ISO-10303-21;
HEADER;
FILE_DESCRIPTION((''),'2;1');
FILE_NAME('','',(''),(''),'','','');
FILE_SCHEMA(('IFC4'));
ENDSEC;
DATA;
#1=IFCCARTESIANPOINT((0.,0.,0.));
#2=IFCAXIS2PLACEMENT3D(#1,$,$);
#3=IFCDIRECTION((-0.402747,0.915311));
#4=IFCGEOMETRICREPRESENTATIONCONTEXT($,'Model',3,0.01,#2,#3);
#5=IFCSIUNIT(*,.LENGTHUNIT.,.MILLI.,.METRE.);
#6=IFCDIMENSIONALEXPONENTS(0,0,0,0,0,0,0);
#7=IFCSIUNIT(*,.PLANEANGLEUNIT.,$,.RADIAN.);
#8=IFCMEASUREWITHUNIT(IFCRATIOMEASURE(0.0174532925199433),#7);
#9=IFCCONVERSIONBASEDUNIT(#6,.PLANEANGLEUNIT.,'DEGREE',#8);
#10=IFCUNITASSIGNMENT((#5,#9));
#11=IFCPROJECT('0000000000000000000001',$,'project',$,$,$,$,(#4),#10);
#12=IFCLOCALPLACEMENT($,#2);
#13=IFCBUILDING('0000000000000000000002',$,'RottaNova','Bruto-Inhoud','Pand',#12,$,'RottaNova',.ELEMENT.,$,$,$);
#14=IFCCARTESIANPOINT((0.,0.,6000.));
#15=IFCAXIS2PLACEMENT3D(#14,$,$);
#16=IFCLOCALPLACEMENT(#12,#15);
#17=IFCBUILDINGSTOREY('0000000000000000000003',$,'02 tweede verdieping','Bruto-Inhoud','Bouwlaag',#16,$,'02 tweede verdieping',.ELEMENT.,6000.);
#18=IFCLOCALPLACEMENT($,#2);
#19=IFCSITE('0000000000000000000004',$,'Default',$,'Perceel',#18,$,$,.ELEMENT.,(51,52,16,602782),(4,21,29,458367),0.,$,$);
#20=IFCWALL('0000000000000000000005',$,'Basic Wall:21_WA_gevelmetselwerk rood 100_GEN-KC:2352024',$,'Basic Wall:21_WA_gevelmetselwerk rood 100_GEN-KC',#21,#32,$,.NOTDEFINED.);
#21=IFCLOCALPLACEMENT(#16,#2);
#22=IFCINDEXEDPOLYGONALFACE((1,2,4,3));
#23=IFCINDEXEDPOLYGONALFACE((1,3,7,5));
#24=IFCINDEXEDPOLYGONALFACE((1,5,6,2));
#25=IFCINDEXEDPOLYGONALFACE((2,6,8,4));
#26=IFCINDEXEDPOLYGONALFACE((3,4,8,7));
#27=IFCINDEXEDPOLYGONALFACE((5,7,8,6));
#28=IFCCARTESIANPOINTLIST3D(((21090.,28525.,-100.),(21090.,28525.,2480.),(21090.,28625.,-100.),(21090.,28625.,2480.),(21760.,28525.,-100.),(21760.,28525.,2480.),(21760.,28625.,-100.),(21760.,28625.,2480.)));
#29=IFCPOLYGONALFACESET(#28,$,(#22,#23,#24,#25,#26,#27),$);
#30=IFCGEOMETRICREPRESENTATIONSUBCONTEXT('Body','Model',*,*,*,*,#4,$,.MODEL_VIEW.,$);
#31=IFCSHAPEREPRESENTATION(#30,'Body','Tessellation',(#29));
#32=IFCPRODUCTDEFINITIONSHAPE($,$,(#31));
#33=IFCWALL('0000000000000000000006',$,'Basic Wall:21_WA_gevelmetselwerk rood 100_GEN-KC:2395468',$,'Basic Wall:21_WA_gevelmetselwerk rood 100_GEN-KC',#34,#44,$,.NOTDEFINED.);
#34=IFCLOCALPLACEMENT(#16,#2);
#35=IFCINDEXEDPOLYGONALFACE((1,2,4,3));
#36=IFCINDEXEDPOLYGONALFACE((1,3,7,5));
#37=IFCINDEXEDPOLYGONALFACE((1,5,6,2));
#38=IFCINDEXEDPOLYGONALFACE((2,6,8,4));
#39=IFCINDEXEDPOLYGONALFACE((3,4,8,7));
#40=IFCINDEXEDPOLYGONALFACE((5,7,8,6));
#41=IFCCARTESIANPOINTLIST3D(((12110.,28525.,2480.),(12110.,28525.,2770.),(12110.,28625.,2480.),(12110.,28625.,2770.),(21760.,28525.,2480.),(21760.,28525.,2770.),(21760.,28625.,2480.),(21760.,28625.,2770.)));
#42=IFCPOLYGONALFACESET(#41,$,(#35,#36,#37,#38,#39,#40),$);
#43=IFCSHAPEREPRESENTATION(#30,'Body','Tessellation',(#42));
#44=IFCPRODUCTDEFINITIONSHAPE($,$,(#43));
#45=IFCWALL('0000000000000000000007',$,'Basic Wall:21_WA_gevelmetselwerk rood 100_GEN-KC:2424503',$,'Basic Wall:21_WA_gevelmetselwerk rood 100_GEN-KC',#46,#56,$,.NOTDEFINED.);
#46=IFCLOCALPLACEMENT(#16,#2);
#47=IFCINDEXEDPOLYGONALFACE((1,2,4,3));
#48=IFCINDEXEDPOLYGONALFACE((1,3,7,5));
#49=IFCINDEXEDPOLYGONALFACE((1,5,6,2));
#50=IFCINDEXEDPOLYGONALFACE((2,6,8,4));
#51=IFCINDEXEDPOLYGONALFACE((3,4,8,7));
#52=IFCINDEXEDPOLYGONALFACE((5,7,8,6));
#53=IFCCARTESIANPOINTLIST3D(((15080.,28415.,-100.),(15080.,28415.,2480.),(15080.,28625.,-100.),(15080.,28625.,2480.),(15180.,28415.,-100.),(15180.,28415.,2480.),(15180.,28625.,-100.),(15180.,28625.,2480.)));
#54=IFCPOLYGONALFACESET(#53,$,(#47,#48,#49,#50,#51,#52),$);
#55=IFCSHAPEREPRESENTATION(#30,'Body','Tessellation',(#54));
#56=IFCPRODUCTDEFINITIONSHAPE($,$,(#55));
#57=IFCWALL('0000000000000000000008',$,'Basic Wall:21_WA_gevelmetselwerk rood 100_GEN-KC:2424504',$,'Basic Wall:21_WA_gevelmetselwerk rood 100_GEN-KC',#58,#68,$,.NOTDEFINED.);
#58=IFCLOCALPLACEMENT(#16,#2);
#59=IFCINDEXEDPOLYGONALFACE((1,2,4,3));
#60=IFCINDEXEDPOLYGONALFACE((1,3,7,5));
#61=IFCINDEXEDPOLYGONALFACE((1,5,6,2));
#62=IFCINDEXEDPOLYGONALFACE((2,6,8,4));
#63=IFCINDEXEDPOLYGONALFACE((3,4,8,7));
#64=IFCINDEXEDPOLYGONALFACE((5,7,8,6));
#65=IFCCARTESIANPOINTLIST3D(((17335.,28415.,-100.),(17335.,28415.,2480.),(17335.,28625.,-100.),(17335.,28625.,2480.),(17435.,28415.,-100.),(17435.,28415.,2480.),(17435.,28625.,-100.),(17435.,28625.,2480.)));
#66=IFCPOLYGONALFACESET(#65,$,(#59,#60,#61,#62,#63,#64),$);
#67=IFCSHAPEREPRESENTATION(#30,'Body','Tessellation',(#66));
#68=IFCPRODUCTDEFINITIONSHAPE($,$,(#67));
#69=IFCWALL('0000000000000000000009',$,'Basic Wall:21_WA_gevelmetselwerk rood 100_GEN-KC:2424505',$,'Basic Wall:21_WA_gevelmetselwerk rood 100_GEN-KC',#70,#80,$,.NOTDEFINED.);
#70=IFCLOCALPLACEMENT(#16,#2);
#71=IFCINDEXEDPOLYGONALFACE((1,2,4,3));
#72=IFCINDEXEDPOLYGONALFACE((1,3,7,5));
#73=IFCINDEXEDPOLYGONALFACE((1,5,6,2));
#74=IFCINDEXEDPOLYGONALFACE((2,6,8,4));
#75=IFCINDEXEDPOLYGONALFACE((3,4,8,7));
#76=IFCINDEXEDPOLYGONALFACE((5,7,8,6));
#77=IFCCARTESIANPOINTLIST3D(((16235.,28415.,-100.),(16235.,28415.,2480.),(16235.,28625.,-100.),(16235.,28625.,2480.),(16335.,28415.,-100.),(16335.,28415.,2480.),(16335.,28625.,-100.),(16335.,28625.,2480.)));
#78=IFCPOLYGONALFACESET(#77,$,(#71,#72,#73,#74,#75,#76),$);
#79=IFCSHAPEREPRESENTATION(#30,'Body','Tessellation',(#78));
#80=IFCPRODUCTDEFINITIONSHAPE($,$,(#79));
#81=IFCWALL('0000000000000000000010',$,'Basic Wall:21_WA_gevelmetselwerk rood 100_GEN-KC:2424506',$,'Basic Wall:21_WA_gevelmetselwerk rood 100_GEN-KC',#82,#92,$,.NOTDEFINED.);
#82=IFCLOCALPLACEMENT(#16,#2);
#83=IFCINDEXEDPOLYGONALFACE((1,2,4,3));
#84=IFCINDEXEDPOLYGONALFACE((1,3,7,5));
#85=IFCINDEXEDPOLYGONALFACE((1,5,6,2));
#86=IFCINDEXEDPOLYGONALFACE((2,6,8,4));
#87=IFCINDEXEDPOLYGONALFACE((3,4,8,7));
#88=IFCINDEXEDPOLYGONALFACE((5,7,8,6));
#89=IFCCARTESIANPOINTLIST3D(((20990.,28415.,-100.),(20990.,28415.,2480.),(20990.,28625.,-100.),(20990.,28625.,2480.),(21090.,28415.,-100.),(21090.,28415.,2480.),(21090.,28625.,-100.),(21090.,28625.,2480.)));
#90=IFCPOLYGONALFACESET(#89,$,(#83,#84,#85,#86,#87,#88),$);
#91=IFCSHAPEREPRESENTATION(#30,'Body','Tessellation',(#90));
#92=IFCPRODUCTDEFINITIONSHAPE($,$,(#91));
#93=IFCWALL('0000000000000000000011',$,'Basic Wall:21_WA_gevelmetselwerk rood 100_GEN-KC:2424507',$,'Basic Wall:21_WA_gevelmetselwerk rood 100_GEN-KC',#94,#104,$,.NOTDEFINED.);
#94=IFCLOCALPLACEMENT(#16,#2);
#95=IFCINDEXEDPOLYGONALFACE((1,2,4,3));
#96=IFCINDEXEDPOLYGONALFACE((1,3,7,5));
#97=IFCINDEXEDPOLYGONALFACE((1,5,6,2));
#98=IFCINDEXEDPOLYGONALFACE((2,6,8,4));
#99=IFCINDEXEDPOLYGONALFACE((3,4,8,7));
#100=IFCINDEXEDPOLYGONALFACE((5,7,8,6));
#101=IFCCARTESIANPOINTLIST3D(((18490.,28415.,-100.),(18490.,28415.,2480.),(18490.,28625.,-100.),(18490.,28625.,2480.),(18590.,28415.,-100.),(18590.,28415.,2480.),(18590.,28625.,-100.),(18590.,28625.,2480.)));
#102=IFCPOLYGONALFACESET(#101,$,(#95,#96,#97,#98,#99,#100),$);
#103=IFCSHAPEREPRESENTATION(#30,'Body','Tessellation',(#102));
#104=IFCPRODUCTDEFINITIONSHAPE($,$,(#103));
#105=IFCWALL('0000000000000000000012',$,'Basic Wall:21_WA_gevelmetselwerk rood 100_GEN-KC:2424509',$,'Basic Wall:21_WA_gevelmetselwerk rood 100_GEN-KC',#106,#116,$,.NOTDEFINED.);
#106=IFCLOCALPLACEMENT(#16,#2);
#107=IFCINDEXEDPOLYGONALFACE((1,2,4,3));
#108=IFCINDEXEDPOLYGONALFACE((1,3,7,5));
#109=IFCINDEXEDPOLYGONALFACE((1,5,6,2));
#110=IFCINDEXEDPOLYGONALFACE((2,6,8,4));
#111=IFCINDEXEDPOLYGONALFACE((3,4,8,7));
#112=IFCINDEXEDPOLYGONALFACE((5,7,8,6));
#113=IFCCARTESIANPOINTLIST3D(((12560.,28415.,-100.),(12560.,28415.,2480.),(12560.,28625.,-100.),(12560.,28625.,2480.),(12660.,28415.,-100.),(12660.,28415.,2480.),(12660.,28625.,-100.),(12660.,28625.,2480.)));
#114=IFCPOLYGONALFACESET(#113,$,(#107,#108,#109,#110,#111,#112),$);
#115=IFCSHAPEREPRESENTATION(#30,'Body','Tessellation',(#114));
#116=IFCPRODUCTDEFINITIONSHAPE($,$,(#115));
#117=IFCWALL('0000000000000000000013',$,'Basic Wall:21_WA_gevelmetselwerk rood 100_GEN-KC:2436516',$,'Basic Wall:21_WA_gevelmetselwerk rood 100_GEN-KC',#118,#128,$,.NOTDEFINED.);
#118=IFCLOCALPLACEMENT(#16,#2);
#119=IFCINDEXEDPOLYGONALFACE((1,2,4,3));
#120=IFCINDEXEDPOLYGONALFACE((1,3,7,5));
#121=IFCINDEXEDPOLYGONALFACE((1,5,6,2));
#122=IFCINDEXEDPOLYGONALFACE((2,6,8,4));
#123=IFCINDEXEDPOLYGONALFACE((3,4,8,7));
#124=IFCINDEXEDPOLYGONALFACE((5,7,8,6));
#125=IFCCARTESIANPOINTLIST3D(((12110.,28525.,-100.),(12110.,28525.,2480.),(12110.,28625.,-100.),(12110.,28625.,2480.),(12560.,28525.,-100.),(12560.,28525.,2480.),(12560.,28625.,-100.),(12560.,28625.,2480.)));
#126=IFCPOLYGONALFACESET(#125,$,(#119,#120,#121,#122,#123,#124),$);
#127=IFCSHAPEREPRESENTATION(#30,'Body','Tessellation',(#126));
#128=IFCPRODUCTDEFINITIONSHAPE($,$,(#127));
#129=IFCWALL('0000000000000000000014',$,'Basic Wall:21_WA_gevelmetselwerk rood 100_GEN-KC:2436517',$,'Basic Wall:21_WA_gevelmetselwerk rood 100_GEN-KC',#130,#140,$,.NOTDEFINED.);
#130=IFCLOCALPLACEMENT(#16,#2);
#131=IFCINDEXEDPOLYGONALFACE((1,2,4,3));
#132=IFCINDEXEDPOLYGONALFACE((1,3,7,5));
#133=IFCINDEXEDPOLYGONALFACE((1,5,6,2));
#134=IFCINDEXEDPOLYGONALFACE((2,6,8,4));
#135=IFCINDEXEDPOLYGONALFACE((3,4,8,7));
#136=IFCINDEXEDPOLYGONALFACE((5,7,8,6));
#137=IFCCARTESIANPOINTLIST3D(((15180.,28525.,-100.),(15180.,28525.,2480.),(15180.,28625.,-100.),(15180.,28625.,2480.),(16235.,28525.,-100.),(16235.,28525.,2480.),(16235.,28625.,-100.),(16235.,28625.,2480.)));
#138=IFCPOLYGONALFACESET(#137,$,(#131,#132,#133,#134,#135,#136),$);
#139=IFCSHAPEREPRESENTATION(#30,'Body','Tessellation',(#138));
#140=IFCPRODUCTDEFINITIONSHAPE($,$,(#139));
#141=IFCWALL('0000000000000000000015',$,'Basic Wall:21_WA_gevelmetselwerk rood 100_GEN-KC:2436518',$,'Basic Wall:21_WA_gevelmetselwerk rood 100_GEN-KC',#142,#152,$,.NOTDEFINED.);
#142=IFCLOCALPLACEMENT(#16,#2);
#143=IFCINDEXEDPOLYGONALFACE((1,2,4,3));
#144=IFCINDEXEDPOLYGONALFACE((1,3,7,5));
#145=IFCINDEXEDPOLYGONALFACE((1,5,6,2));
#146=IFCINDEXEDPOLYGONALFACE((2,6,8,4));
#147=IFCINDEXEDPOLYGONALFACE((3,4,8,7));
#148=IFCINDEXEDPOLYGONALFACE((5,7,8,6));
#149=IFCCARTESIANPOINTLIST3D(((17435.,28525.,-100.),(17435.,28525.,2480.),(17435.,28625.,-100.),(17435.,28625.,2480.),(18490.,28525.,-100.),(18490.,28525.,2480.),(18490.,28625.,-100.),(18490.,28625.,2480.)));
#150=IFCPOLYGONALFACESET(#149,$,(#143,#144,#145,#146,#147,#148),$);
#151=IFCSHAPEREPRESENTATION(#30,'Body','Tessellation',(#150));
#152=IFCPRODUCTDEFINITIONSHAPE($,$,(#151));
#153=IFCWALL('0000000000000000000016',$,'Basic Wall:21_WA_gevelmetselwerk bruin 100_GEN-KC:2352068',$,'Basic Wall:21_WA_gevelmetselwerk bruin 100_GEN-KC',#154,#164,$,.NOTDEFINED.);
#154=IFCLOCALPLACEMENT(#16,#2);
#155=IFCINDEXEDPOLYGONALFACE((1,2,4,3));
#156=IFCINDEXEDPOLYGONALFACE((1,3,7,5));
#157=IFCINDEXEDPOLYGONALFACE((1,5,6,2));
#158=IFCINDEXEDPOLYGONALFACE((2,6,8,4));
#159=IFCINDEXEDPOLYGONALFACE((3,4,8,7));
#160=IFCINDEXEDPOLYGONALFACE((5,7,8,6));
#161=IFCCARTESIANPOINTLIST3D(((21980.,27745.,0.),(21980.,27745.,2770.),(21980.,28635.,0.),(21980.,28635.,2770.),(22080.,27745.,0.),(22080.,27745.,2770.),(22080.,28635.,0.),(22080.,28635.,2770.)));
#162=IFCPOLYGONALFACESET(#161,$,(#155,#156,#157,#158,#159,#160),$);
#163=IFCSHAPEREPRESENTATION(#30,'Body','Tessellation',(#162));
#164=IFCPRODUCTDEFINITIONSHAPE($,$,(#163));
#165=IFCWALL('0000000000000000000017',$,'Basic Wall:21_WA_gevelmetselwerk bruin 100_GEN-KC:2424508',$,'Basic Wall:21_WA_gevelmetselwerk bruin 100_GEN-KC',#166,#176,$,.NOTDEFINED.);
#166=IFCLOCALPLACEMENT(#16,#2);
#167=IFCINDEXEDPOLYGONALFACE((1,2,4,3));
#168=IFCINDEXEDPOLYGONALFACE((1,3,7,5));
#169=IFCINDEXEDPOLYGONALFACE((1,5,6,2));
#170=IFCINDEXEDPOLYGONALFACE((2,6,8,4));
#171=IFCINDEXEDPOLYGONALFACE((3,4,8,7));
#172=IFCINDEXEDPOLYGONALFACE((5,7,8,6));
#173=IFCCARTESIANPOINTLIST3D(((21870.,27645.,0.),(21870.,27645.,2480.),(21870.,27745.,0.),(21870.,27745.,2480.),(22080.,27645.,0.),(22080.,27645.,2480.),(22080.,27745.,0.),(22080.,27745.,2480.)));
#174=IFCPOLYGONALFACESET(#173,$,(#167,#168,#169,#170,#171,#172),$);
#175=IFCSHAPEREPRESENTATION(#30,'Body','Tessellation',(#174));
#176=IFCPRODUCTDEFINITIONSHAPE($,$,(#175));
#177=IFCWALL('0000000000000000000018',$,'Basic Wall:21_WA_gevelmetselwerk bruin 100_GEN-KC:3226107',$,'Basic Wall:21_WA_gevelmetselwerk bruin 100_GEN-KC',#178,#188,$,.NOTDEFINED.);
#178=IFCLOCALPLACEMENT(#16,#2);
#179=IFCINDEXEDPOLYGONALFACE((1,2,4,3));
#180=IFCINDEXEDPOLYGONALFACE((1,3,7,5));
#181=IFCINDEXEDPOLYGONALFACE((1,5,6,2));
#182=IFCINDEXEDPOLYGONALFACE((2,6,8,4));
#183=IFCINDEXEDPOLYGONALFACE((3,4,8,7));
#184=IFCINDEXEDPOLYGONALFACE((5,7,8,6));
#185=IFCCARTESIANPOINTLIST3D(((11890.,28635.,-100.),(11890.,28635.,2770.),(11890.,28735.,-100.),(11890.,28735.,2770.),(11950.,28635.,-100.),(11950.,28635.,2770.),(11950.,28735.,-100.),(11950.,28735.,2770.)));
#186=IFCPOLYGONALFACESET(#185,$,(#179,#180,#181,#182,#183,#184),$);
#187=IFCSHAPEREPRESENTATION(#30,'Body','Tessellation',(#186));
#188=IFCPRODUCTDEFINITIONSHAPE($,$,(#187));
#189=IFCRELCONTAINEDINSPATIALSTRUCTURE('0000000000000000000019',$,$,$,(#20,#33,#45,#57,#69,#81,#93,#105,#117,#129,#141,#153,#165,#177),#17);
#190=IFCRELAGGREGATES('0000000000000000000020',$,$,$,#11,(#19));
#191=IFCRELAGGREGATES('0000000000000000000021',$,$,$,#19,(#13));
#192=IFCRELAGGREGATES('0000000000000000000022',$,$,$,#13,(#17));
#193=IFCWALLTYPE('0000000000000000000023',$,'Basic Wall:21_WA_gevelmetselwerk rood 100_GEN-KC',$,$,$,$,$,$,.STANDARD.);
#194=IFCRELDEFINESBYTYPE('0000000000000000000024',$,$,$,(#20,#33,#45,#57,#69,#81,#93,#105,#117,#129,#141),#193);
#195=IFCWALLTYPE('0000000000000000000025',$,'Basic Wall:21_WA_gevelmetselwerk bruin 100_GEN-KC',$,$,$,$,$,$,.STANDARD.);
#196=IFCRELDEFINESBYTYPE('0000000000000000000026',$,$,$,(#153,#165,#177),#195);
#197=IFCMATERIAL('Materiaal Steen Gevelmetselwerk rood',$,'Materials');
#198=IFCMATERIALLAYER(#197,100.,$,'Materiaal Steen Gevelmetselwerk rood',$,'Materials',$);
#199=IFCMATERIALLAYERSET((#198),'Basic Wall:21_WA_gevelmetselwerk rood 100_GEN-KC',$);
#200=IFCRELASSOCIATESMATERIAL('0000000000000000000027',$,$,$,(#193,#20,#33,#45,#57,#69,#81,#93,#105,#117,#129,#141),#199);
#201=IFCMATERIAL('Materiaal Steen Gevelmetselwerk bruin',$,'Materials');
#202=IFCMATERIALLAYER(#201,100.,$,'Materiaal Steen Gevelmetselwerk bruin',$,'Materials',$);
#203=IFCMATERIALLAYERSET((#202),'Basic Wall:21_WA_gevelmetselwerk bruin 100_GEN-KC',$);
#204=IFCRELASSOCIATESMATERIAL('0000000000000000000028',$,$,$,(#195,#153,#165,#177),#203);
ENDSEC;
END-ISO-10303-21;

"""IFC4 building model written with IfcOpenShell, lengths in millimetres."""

from ifc_helpers import new_model, entity, si_unit, converted_unit, direction, frame, frame_2d, origin, place, context, subcontext, project, spatial, rectangle, extrude, material, layer, layer_set, type_object, element, save


model = new_model("IFC4")

# Units and contexts
model_context = context("Model", 3, precision=0.01, world=origin(), true_north=direction((-0.402747, 0.915311)))
body_context = subcontext(model_context, "Body", "Model", "MODEL_VIEW")
ifc_project = project(units=[si_unit("LENGTHUNIT", "METRE", prefix="MILLI"), converted_unit("PLANEANGLEUNIT", "DEGREE", entity("IfcRatioMeasure", 0.0174532925199433), si_unit("PLANEANGLEUNIT", "RADIAN"), dimensions=[0, 0, 0, 0, 0, 0, 0])], contexts=[model_context])

# Site, building, storey
site_placement = place(None, origin())
site = spatial("IfcSite", under=ifc_project, at=site_placement, Name="Default", ObjectType="Perceel", CompositionType="ELEMENT", RefLatitude=(51, 52, 16, 602782), RefLongitude=(4, 21, 29, 458367), RefElevation=0.0)
building_placement = place(None, origin())
building = spatial("IfcBuilding", under=site, at=building_placement, Name="RottaNova", Description="Bruto-Inhoud", ObjectType="Pand", LongName="RottaNova", CompositionType="ELEMENT")
storey_placement = place(building_placement, frame((0.0, 0.0, 6000.0)))
storey = spatial("IfcBuildingStorey", under=building, at=storey_placement, Name="02 tweede verdieping", Description="Bruto-Inhoud", ObjectType="Bouwlaag", LongName="02 tweede verdieping", CompositionType="ELEMENT", Elevation=6000.0)

# Walls
ifc_material_1 = material(Name="Materiaal Steen Gevelmetselwerk rood", Category="Materials")
ifc_layer_1 = layer(ifc_material_1, 100.0, Name="Materiaal Steen Gevelmetselwerk rood", Category="Materials")
ifc_layer_set_1 = layer_set([ifc_layer_1], Name="Basic Wall:21_WA_gevelmetselwerk rood 100_GEN-KC")
wall_type_1 = type_object("IfcWallType", Name="Basic Wall:21_WA_gevelmetselwerk rood 100_GEN-KC", PredefinedType="STANDARD", material=ifc_layer_set_1)
wall_1_placement = place(storey_placement, frame((21760.0, 28575.0, -100.0), z_axis=(0.0, 0.0, 1.0), x_axis=(-1.0, 0.0, 0.0)))
element("IfcWall", 1, at=wall_1_placement, inside=storey, type_object=wall_type_1, material=ifc_layer_set_1, Name="Basic Wall:21_WA_gevelmetselwerk rood 100_GEN-KC:2352024", ObjectType="Basic Wall:21_WA_gevelmetselwerk rood 100_GEN-KC", PredefinedType="NOTDEFINED", context=body_context, shape_type="SweptSolid", body=[
    extrude(rectangle(XDim=670.0, YDim=100.0, at=frame_2d((335.0, 0.0), x_axis=(-1.0, 0.0))), origin(), (0.0, 0.0, 1.0), 2580.0),
])
wall_2_placement = place(storey_placement, frame((21760.0, 28575.0, 2480.0), z_axis=(0.0, 0.0, 1.0), x_axis=(-1.0, 0.0, 0.0)))
element("IfcWall", 2, at=wall_2_placement, inside=storey, type_object=wall_type_1, material=ifc_layer_set_1, Name="Basic Wall:21_WA_gevelmetselwerk rood 100_GEN-KC:2395468", ObjectType="Basic Wall:21_WA_gevelmetselwerk rood 100_GEN-KC", PredefinedType="NOTDEFINED", context=body_context, shape_type="SweptSolid", body=[
    extrude(rectangle(XDim=9650.0, YDim=100.0, at=frame_2d((4825.0, 0.0), x_axis=(-1.0, 0.0))), origin(), (0.0, 0.0, 1.0), 290.0),
])
for number, where, z_axis, x_axis, name in (
    (3, (15130.0, 28415.0, -100.0), (0.0, 0.0, 1.0), (0.0, 1.0, 0.0), "Basic Wall:21_WA_gevelmetselwerk rood 100_GEN-KC:2424503"),
    (4, (17385.0, 28415.0, -100.0), (0.0, 0.0, 1.0), (0.0, 1.0, 0.0), "Basic Wall:21_WA_gevelmetselwerk rood 100_GEN-KC:2424504"),
    (5, (16285.0, 28415.0, -100.0), (0.0, 0.0, 1.0), (0.0, 1.0, 0.0), "Basic Wall:21_WA_gevelmetselwerk rood 100_GEN-KC:2424505"),
):
    element("IfcWall", number, at=place(storey_placement, frame(where, z_axis=z_axis, x_axis=x_axis)), inside=storey, type_object=wall_type_1, material=ifc_layer_set_1, Name=name, ObjectType="Basic Wall:21_WA_gevelmetselwerk rood 100_GEN-KC", PredefinedType="NOTDEFINED", context=body_context, shape_type="SweptSolid", body=[
        extrude(rectangle(XDim=210.0, YDim=100.0, at=frame_2d((105.0, 0.0), x_axis=(-1.0, 0.0))), origin(), (0.0, 0.0, 1.0), 2580.0),
    ])
wall_3_placement = place(storey_placement, frame((21040.0, 28415.0, -100.0), z_axis=(0.0, 0.0, 1.0), x_axis=(0.0, 1.0, 0.0)))
element("IfcWall", 6, at=wall_3_placement, inside=storey, type_object=wall_type_1, material=ifc_layer_set_1, Name="Basic Wall:21_WA_gevelmetselwerk rood 100_GEN-KC:2424506", ObjectType="Basic Wall:21_WA_gevelmetselwerk rood 100_GEN-KC", PredefinedType="NOTDEFINED", context=body_context, shape_type="SweptSolid", body=[
    extrude(rectangle(XDim=210.0, YDim=100.0, at=frame_2d((105.0, 0.0), x_axis=(-1.0, 0.0))), origin(), (0.0, 0.0, 1.0), 2580.0),
])
wall_4_placement = place(storey_placement, frame((18540.0, 28415.0, -100.0), z_axis=(0.0, 0.0, 1.0), x_axis=(0.0, 1.0, 0.0)))
element("IfcWall", 7, at=wall_4_placement, inside=storey, type_object=wall_type_1, material=ifc_layer_set_1, Name="Basic Wall:21_WA_gevelmetselwerk rood 100_GEN-KC:2424507", ObjectType="Basic Wall:21_WA_gevelmetselwerk rood 100_GEN-KC", PredefinedType="NOTDEFINED", context=body_context, shape_type="SweptSolid", body=[
    extrude(rectangle(XDim=210.0, YDim=100.0, at=frame_2d((105.0, 0.0), x_axis=(-1.0, 0.0))), origin(), (0.0, 0.0, 1.0), 2580.0),
])
wall_5_placement = place(storey_placement, frame((12610.0, 28415.0, -100.0), z_axis=(0.0, 0.0, 1.0), x_axis=(0.0, 1.0, 0.0)))
element("IfcWall", 8, at=wall_5_placement, inside=storey, type_object=wall_type_1, material=ifc_layer_set_1, Name="Basic Wall:21_WA_gevelmetselwerk rood 100_GEN-KC:2424509", ObjectType="Basic Wall:21_WA_gevelmetselwerk rood 100_GEN-KC", PredefinedType="NOTDEFINED", context=body_context, shape_type="SweptSolid", body=[
    extrude(rectangle(XDim=210.0, YDim=100.0, at=frame_2d((105.0, 0.0), x_axis=(-1.0, 0.0))), origin(), (0.0, 0.0, 1.0), 2580.0),
])
wall_6_placement = place(storey_placement, frame((12560.0, 28575.0, -100.0), z_axis=(0.0, 0.0, 1.0), x_axis=(-1.0, 0.0, 0.0)))
element("IfcWall", 9, at=wall_6_placement, inside=storey, type_object=wall_type_1, material=ifc_layer_set_1, Name="Basic Wall:21_WA_gevelmetselwerk rood 100_GEN-KC:2436516", ObjectType="Basic Wall:21_WA_gevelmetselwerk rood 100_GEN-KC", PredefinedType="NOTDEFINED", context=body_context, shape_type="SweptSolid", body=[
    extrude(rectangle(XDim=450.0, YDim=100.0, at=frame_2d((225.0, 0.0), x_axis=(-1.0, 0.0))), origin(), (0.0, 0.0, 1.0), 2580.0),
])
wall_7_placement = place(storey_placement, frame((16235.0, 28575.0, -100.0), z_axis=(0.0, 0.0, 1.0), x_axis=(-1.0, 0.0, 0.0)))
element("IfcWall", 10, at=wall_7_placement, inside=storey, type_object=wall_type_1, material=ifc_layer_set_1, Name="Basic Wall:21_WA_gevelmetselwerk rood 100_GEN-KC:2436517", ObjectType="Basic Wall:21_WA_gevelmetselwerk rood 100_GEN-KC", PredefinedType="NOTDEFINED", context=body_context, shape_type="SweptSolid", body=[
    extrude(rectangle(XDim=1055.0, YDim=100.0, at=frame_2d((527.5, 0.0), x_axis=(-1.0, 0.0))), origin(), (0.0, 0.0, 1.0), 2580.0),
])
wall_8_placement = place(storey_placement, frame((18490.0, 28575.0, -100.0), z_axis=(0.0, 0.0, 1.0), x_axis=(-1.0, 0.0, 0.0)))
element("IfcWall", 11, at=wall_8_placement, inside=storey, type_object=wall_type_1, material=ifc_layer_set_1, Name="Basic Wall:21_WA_gevelmetselwerk rood 100_GEN-KC:2436518", ObjectType="Basic Wall:21_WA_gevelmetselwerk rood 100_GEN-KC", PredefinedType="NOTDEFINED", context=body_context, shape_type="SweptSolid", body=[
    extrude(rectangle(XDim=1055.0, YDim=100.0, at=frame_2d((527.5, 0.0), x_axis=(-1.0, 0.0))), origin(), (0.0, 0.0, 1.0), 2580.0),
])
ifc_material_2 = material(Name="Materiaal Steen Gevelmetselwerk bruin", Category="Materials")
ifc_layer_2 = layer(ifc_material_2, 100.0, Name="Materiaal Steen Gevelmetselwerk bruin", Category="Materials")
ifc_layer_set_2 = layer_set([ifc_layer_2], Name="Basic Wall:21_WA_gevelmetselwerk bruin 100_GEN-KC")
wall_type_2 = type_object("IfcWallType", Name="Basic Wall:21_WA_gevelmetselwerk bruin 100_GEN-KC", PredefinedType="STANDARD", material=ifc_layer_set_2)
wall_9_placement = place(storey_placement, frame((22030.0, 27745.0, 0.0), z_axis=(0.0, 0.0, 1.0), x_axis=(0.0, 1.0, 0.0)))
element("IfcWall", 12, at=wall_9_placement, inside=storey, type_object=wall_type_2, material=ifc_layer_set_2, Name="Basic Wall:21_WA_gevelmetselwerk bruin 100_GEN-KC:2352068", ObjectType="Basic Wall:21_WA_gevelmetselwerk bruin 100_GEN-KC", PredefinedType="NOTDEFINED", context=body_context, shape_type="SweptSolid", body=[
    extrude(rectangle(XDim=890.0, YDim=100.0, at=frame_2d((445.0, 0.0), x_axis=(-1.0, 0.0))), origin(), (0.0, 0.0, 1.0), 2770.0),
])
wall_10_placement = place(storey_placement, frame((21870.0, 27695.0, 0.0)))
element("IfcWall", 13, at=wall_10_placement, inside=storey, type_object=wall_type_2, material=ifc_layer_set_2, Name="Basic Wall:21_WA_gevelmetselwerk bruin 100_GEN-KC:2424508", ObjectType="Basic Wall:21_WA_gevelmetselwerk bruin 100_GEN-KC", PredefinedType="NOTDEFINED", context=body_context, shape_type="SweptSolid", body=[
    extrude(rectangle(XDim=210.0, YDim=100.0, at=frame_2d((105.0, 0.0), x_axis=(-1.0, 0.0))), origin(), (0.0, 0.0, 1.0), 2480.0),
])
wall_11_placement = place(storey_placement, frame((11890.0, 28685.0, -100.0)))
element("IfcWall", 14, at=wall_11_placement, inside=storey, type_object=wall_type_2, material=ifc_layer_set_2, Name="Basic Wall:21_WA_gevelmetselwerk bruin 100_GEN-KC:3226107", ObjectType="Basic Wall:21_WA_gevelmetselwerk bruin 100_GEN-KC", PredefinedType="NOTDEFINED", context=body_context, shape_type="SweptSolid", body=[
    extrude(rectangle(XDim=60.0, YDim=100.0, at=frame_2d((30.0, 0.0), x_axis=(-1.0, 0.0))), origin(), (0.0, 0.0, 1.0), 2870.0),
])

save(model, "model.ifc")
